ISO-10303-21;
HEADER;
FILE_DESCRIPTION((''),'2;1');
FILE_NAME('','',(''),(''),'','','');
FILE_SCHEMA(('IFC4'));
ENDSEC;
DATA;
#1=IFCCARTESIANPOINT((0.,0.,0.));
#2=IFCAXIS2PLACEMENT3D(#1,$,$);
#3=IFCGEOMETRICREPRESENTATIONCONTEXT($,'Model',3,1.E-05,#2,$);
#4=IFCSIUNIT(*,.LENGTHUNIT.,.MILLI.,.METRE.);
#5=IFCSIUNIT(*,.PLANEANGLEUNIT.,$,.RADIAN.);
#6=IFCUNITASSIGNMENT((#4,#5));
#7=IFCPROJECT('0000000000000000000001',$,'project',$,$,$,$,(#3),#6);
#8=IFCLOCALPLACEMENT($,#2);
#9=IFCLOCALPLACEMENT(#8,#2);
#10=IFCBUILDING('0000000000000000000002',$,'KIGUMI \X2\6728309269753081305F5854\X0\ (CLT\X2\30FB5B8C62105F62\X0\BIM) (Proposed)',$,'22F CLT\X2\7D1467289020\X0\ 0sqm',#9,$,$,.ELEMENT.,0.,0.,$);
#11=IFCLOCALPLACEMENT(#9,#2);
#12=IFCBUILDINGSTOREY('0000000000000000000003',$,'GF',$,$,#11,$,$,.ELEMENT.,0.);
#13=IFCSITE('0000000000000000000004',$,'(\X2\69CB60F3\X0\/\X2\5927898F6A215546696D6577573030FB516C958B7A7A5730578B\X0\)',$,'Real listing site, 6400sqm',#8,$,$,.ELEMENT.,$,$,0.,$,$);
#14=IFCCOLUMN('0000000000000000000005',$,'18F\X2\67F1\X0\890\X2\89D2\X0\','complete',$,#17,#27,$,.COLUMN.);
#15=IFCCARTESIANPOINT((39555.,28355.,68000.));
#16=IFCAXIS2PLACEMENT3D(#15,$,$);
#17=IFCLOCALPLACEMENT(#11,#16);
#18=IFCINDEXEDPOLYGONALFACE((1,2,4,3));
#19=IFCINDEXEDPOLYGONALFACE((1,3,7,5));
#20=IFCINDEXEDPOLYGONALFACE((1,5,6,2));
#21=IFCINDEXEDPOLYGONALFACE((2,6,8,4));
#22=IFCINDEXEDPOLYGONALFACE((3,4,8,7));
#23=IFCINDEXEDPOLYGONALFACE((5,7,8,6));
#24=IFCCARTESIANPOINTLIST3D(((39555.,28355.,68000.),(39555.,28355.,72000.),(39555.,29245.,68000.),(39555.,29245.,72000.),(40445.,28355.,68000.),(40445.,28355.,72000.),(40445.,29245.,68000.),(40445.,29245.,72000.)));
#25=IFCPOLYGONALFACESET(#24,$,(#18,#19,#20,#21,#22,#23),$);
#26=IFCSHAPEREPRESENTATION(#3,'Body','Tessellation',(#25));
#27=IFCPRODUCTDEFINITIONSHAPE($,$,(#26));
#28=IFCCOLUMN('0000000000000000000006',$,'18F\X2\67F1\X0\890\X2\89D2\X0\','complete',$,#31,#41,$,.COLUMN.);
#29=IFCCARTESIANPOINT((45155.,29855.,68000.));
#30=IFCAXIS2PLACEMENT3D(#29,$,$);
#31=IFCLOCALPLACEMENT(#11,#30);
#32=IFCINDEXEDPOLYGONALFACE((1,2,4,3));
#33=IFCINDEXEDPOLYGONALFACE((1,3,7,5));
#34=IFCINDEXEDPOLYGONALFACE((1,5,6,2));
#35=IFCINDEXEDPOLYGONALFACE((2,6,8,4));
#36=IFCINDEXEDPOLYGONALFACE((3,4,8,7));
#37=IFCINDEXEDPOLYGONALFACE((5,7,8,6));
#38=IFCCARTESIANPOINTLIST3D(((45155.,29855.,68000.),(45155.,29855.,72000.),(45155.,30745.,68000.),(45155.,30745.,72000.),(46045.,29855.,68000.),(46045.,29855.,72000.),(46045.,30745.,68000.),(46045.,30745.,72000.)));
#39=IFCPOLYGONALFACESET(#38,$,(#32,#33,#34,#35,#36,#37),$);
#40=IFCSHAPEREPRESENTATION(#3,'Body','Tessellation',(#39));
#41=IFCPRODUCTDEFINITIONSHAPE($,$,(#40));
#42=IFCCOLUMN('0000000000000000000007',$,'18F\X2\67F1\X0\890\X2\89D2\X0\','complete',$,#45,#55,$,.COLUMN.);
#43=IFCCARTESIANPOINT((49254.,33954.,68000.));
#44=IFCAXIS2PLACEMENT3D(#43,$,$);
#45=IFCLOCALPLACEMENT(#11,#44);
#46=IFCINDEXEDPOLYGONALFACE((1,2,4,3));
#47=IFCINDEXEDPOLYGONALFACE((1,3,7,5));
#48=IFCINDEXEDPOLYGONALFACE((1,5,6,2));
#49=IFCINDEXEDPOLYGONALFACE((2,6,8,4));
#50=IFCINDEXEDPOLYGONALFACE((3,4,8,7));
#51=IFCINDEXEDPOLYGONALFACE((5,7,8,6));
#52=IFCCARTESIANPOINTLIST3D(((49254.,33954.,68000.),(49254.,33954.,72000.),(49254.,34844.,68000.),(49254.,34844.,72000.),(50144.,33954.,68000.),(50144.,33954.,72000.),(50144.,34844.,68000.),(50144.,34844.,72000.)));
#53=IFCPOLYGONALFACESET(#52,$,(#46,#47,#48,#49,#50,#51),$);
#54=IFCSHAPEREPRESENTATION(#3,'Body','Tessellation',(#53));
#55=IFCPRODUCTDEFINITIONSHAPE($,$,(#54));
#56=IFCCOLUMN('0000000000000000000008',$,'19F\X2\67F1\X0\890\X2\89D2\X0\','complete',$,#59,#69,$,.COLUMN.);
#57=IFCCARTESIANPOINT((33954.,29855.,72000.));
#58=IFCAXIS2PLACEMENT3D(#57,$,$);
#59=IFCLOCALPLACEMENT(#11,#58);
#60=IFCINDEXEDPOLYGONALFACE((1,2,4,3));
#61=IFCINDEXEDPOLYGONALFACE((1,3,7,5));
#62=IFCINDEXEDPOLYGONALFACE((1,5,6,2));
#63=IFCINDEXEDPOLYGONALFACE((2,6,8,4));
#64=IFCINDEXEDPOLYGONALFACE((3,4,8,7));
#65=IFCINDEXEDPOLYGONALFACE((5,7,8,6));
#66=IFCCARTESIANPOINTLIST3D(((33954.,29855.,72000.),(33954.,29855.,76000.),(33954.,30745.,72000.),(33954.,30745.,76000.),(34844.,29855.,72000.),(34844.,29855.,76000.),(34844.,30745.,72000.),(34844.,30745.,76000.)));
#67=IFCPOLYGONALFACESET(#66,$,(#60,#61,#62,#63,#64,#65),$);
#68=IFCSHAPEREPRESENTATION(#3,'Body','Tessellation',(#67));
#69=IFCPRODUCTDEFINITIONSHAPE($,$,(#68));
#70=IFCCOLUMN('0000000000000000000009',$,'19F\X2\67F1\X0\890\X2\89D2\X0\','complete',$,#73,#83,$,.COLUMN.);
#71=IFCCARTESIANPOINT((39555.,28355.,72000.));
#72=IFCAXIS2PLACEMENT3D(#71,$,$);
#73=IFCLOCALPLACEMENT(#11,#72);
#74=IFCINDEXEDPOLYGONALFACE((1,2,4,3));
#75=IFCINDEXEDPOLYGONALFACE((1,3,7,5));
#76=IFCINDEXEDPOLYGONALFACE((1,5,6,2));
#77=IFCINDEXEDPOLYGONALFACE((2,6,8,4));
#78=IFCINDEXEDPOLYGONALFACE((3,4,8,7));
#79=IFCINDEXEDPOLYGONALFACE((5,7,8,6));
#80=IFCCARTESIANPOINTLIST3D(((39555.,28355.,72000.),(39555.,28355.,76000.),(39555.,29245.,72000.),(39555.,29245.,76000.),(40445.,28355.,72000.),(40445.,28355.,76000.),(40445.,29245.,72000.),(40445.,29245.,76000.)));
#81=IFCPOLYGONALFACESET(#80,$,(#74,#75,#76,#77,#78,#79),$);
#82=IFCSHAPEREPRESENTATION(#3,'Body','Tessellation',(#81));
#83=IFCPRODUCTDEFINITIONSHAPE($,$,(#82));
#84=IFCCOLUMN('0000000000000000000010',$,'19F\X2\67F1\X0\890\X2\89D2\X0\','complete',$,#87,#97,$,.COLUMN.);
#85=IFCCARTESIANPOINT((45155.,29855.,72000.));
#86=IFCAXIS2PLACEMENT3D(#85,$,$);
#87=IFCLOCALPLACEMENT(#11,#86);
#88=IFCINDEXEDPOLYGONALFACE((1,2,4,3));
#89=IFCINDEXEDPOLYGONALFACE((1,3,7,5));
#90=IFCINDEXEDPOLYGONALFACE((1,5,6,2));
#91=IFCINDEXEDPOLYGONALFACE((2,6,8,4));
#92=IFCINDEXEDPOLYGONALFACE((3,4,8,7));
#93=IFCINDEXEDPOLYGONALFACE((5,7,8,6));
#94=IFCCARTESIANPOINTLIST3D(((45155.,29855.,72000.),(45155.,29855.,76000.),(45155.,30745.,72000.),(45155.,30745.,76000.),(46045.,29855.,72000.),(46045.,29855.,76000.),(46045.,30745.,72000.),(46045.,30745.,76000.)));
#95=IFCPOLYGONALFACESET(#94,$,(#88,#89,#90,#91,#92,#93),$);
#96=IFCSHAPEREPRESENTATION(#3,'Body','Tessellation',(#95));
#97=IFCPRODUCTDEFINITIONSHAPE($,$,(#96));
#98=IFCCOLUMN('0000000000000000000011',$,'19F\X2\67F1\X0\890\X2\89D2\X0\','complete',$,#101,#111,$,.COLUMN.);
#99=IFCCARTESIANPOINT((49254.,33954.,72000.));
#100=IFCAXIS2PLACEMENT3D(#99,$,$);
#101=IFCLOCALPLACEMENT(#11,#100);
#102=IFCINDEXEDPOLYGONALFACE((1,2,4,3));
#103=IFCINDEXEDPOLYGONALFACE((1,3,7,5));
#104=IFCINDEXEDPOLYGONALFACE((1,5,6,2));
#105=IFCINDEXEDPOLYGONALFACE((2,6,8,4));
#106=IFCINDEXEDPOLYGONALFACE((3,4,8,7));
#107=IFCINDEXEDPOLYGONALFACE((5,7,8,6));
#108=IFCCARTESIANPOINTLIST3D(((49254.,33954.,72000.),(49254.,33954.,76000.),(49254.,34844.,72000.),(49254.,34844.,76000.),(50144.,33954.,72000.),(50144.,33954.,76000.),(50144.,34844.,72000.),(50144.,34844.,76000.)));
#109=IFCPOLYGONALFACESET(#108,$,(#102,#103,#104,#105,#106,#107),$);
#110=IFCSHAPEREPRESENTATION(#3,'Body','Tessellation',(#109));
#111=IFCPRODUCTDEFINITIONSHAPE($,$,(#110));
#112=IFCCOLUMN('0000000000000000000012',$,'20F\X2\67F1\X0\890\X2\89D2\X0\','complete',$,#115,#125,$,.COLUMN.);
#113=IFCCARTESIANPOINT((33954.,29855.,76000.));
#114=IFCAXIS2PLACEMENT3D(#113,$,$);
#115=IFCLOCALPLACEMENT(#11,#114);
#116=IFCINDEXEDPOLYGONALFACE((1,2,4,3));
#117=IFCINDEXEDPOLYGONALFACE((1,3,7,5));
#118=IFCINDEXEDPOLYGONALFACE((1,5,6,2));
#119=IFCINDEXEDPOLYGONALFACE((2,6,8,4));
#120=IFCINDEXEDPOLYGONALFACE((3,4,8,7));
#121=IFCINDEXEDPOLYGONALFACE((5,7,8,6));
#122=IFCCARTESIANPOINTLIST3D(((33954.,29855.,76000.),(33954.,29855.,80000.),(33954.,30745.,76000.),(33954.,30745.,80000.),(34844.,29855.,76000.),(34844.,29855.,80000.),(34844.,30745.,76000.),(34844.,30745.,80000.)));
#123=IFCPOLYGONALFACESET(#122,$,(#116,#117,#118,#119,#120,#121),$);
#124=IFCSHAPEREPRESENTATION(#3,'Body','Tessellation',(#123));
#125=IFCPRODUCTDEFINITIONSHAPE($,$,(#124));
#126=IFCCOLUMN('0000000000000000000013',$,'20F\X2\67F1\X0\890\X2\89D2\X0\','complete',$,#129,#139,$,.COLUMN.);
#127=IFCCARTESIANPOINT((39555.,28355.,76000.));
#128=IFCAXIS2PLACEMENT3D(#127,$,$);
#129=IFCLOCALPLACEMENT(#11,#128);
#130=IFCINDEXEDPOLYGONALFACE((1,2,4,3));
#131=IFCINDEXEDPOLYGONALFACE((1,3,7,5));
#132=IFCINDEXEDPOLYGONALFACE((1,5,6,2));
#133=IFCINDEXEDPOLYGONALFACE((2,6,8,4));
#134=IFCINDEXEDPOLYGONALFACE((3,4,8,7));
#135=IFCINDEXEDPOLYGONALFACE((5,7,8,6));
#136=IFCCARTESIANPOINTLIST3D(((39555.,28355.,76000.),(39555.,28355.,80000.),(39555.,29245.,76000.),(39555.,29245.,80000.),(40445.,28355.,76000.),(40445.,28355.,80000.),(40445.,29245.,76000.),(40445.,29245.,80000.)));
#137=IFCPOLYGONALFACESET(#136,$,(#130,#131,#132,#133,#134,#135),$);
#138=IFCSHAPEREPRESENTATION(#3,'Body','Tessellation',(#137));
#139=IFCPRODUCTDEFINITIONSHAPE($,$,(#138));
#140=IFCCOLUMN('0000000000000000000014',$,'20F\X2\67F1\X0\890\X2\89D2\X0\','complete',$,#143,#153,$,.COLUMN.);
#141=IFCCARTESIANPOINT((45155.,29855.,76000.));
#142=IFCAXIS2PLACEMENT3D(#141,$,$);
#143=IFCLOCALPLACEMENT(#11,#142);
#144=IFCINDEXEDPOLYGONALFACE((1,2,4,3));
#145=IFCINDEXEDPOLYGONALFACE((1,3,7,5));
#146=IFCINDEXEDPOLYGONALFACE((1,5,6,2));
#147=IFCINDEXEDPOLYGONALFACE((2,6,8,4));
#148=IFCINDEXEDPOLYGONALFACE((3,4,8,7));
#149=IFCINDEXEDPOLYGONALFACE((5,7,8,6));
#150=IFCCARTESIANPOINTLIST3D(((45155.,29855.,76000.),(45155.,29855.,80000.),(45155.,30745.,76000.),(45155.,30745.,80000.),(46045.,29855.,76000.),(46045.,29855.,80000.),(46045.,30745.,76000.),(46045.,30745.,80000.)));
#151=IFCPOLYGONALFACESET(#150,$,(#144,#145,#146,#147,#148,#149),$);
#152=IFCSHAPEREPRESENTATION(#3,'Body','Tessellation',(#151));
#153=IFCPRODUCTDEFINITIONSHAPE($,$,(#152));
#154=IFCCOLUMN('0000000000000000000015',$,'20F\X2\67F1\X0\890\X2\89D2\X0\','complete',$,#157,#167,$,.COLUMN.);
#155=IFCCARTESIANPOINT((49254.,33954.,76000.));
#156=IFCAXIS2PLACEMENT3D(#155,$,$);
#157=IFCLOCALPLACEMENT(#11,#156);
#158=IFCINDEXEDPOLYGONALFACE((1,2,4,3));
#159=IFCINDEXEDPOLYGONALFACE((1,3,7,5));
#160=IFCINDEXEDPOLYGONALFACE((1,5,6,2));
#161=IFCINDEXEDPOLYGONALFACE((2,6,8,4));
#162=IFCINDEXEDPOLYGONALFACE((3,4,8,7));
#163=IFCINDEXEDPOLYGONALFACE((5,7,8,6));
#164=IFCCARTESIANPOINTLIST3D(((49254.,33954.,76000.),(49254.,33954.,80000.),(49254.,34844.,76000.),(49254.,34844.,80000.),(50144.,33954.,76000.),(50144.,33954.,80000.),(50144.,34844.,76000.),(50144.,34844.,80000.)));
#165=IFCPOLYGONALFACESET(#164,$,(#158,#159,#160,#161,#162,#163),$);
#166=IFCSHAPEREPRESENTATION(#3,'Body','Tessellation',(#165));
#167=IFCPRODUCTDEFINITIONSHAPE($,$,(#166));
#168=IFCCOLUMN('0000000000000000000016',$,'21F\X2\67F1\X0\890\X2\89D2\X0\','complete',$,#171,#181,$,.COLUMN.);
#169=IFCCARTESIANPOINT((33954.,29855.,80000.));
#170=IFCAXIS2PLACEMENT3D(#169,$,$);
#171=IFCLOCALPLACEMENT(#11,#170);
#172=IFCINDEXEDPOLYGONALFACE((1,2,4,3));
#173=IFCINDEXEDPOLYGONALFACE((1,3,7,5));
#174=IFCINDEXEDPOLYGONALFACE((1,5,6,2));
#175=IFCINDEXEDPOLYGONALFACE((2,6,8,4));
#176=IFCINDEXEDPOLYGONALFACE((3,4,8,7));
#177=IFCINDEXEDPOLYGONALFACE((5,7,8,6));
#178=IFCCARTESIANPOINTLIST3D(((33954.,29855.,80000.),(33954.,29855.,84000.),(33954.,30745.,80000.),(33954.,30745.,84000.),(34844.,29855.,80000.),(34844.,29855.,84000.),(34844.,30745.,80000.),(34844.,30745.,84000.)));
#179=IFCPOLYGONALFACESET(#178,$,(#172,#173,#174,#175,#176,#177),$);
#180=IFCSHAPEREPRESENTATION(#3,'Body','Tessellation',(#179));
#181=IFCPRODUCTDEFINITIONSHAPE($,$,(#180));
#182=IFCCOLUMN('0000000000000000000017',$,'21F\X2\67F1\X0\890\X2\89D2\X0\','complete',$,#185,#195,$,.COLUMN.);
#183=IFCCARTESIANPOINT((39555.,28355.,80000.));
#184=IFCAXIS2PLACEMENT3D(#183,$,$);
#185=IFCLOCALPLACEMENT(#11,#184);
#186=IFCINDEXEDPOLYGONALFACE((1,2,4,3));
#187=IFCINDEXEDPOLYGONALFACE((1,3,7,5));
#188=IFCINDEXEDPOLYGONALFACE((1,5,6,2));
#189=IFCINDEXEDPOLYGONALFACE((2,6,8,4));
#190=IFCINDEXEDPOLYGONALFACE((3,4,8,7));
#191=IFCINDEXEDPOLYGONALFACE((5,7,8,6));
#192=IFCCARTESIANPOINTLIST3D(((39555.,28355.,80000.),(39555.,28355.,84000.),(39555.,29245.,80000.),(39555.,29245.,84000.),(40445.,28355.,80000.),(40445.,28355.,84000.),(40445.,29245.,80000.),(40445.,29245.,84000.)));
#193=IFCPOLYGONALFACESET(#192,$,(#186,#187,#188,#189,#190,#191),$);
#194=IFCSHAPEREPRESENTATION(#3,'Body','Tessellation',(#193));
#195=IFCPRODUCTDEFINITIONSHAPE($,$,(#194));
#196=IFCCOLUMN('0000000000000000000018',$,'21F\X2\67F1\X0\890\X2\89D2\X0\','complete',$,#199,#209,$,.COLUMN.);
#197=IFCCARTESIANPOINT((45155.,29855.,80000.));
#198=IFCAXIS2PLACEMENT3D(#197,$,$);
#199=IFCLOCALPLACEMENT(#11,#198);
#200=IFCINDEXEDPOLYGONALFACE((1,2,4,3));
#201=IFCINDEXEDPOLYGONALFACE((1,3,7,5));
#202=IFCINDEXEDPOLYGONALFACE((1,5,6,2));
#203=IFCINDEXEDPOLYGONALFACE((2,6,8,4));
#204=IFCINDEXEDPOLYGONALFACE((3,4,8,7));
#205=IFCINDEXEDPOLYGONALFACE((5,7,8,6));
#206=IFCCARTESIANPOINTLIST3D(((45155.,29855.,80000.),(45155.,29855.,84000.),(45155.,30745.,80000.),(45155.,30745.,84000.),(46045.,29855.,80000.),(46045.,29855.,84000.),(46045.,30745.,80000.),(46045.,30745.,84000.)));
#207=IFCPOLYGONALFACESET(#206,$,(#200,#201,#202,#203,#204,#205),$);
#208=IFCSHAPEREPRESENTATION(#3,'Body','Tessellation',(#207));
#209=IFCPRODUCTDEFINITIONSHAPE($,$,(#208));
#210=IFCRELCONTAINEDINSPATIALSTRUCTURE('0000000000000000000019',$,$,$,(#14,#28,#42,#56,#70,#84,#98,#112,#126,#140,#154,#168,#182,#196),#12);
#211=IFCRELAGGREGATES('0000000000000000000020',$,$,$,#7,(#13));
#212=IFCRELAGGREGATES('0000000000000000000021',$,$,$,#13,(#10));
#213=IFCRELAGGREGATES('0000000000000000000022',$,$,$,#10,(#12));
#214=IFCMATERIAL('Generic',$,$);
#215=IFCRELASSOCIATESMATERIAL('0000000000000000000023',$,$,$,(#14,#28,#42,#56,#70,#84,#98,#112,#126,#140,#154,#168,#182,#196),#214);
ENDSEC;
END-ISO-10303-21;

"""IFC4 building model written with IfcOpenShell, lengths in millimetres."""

from ifc_helpers import new_model, si_unit, frame, frame_2d, origin, place, context, project, spatial, rectangle, extrude, material, element, save


model = new_model("IFC4")

# Units and contexts
model_context = context("Model", 3, precision=1e-05, world=origin())
ifc_project = project(units=[si_unit("LENGTHUNIT", "METRE", prefix="MILLI"), si_unit("PLANEANGLEUNIT", "RADIAN")], contexts=[model_context])

# Site, building, storey
site_placement = place(None, origin())
site = spatial("IfcSite", under=ifc_project, at=site_placement, Name="(構想/大規模商業敷地・公開空地型)", ObjectType="Real listing site, 6400sqm", CompositionType="ELEMENT", RefElevation=0.0)
building_placement = place(site_placement, origin())
building = spatial("IfcBuilding", under=site, at=building_placement, Name="KIGUMI 木を極めた塔 (CLT・完成形BIM) (Proposed)", ObjectType="22F CLT純木造 0sqm", CompositionType="ELEMENT", ElevationOfRefHeight=0.0, ElevationOfTerrain=0.0)
storey_placement = place(building_placement, origin())
storey = spatial("IfcBuildingStorey", under=building, at=storey_placement, Name="GF", CompositionType="ELEMENT", Elevation=0.0)

# Columns
ifc_material = material(Name="Generic")
column_1_placement = place(storey_placement, frame((39555.0, 28355.0, 68000.0)))
element("IfcColumn", 1, at=column_1_placement, inside=storey, material=ifc_material, Name="18F柱890角", Description="complete", PredefinedType="COLUMN", context=model_context, shape_type="SweptSolid", body=[
    extrude(rectangle(XDim=890.0, YDim=890.0, at=frame_2d((445.0, 445.0))), frame((39555.0, 28355.0, 68000.0)), (0.0, 0.0, 1.0), 4000.0),
])
column_2_placement = place(storey_placement, frame((45155.0, 29855.0, 68000.0)))
element("IfcColumn", 2, at=column_2_placement, inside=storey, material=ifc_material, Name="18F柱890角", Description="complete", PredefinedType="COLUMN", context=model_context, shape_type="SweptSolid", body=[
    extrude(rectangle(XDim=890.0, YDim=890.0, at=frame_2d((445.0, 445.0))), frame((45155.0, 29855.0, 68000.0)), (0.0, 0.0, 1.0), 4000.0),
])
column_3_placement = place(storey_placement, frame((49254.0, 33954.0, 68000.0)))
element("IfcColumn", 3, at=column_3_placement, inside=storey, material=ifc_material, Name="18F柱890角", Description="complete", PredefinedType="COLUMN", context=model_context, shape_type="SweptSolid", body=[
    extrude(rectangle(XDim=890.0, YDim=890.0, at=frame_2d((445.0, 445.0))), frame((49254.0, 33954.0, 68000.0)), (0.0, 0.0, 1.0), 4000.0),
])
column_4_placement = place(storey_placement, frame((33954.0, 29855.0, 72000.0)))
element("IfcColumn", 4, at=column_4_placement, inside=storey, material=ifc_material, Name="19F柱890角", Description="complete", PredefinedType="COLUMN", context=model_context, shape_type="SweptSolid", body=[
    extrude(rectangle(XDim=890.0, YDim=890.0, at=frame_2d((445.0, 445.0))), frame((33954.0, 29855.0, 72000.0)), (0.0, 0.0, 1.0), 4000.0),
])
column_5_placement = place(storey_placement, frame((39555.0, 28355.0, 72000.0)))
element("IfcColumn", 5, at=column_5_placement, inside=storey, material=ifc_material, Name="19F柱890角", Description="complete", PredefinedType="COLUMN", context=model_context, shape_type="SweptSolid", body=[
    extrude(rectangle(XDim=890.0, YDim=890.0, at=frame_2d((445.0, 445.0))), frame((39555.0, 28355.0, 72000.0)), (0.0, 0.0, 1.0), 4000.0),
])
column_6_placement = place(storey_placement, frame((45155.0, 29855.0, 72000.0)))
element("IfcColumn", 6, at=column_6_placement, inside=storey, material=ifc_material, Name="19F柱890角", Description="complete", PredefinedType="COLUMN", context=model_context, shape_type="SweptSolid", body=[
    extrude(rectangle(XDim=890.0, YDim=890.0, at=frame_2d((445.0, 445.0))), frame((45155.0, 29855.0, 72000.0)), (0.0, 0.0, 1.0), 4000.0),
])
column_7_placement = place(storey_placement, frame((49254.0, 33954.0, 72000.0)))
element("IfcColumn", 7, at=column_7_placement, inside=storey, material=ifc_material, Name="19F柱890角", Description="complete", PredefinedType="COLUMN", context=model_context, shape_type="SweptSolid", body=[
    extrude(rectangle(XDim=890.0, YDim=890.0, at=frame_2d((445.0, 445.0))), frame((49254.0, 33954.0, 72000.0)), (0.0, 0.0, 1.0), 4000.0),
])
column_8_placement = place(storey_placement, frame((33954.0, 29855.0, 76000.0)))
element("IfcColumn", 8, at=column_8_placement, inside=storey, material=ifc_material, Name="20F柱890角", Description="complete", PredefinedType="COLUMN", context=model_context, shape_type="SweptSolid", body=[
    extrude(rectangle(XDim=890.0, YDim=890.0, at=frame_2d((445.0, 445.0))), frame((33954.0, 29855.0, 76000.0)), (0.0, 0.0, 1.0), 4000.0),
])
column_9_placement = place(storey_placement, frame((39555.0, 28355.0, 76000.0)))
element("IfcColumn", 9, at=column_9_placement, inside=storey, material=ifc_material, Name="20F柱890角", Description="complete", PredefinedType="COLUMN", context=model_context, shape_type="SweptSolid", body=[
    extrude(rectangle(XDim=890.0, YDim=890.0, at=frame_2d((445.0, 445.0))), frame((39555.0, 28355.0, 76000.0)), (0.0, 0.0, 1.0), 4000.0),
])
column_10_placement = place(storey_placement, frame((45155.0, 29855.0, 76000.0)))
element("IfcColumn", 10, at=column_10_placement, inside=storey, material=ifc_material, Name="20F柱890角", Description="complete", PredefinedType="COLUMN", context=model_context, shape_type="SweptSolid", body=[
    extrude(rectangle(XDim=890.0, YDim=890.0, at=frame_2d((445.0, 445.0))), frame((45155.0, 29855.0, 76000.0)), (0.0, 0.0, 1.0), 4000.0),
])
column_11_placement = place(storey_placement, frame((49254.0, 33954.0, 76000.0)))
element("IfcColumn", 11, at=column_11_placement, inside=storey, material=ifc_material, Name="20F柱890角", Description="complete", PredefinedType="COLUMN", context=model_context, shape_type="SweptSolid", body=[
    extrude(rectangle(XDim=890.0, YDim=890.0, at=frame_2d((445.0, 445.0))), frame((49254.0, 33954.0, 76000.0)), (0.0, 0.0, 1.0), 4000.0),
])
column_12_placement = place(storey_placement, frame((33954.0, 29855.0, 80000.0)))
element("IfcColumn", 12, at=column_12_placement, inside=storey, material=ifc_material, Name="21F柱890角", Description="complete", PredefinedType="COLUMN", context=model_context, shape_type="SweptSolid", body=[
    extrude(rectangle(XDim=890.0, YDim=890.0, at=frame_2d((445.0, 445.0))), frame((33954.0, 29855.0, 80000.0)), (0.0, 0.0, 1.0), 4000.0),
])
column_13_placement = place(storey_placement, frame((39555.0, 28355.0, 80000.0)))
element("IfcColumn", 13, at=column_13_placement, inside=storey, material=ifc_material, Name="21F柱890角", Description="complete", PredefinedType="COLUMN", context=model_context, shape_type="SweptSolid", body=[
    extrude(rectangle(XDim=890.0, YDim=890.0, at=frame_2d((445.0, 445.0))), frame((39555.0, 28355.0, 80000.0)), (0.0, 0.0, 1.0), 4000.0),
])
column_14_placement = place(storey_placement, frame((45155.0, 29855.0, 80000.0)))
element("IfcColumn", 14, at=column_14_placement, inside=storey, material=ifc_material, Name="21F柱890角", Description="complete", PredefinedType="COLUMN", context=model_context, shape_type="SweptSolid", body=[
    extrude(rectangle(XDim=890.0, YDim=890.0, at=frame_2d((445.0, 445.0))), frame((45155.0, 29855.0, 80000.0)), (0.0, 0.0, 1.0), 4000.0),
])

save(model, "model.ifc")
